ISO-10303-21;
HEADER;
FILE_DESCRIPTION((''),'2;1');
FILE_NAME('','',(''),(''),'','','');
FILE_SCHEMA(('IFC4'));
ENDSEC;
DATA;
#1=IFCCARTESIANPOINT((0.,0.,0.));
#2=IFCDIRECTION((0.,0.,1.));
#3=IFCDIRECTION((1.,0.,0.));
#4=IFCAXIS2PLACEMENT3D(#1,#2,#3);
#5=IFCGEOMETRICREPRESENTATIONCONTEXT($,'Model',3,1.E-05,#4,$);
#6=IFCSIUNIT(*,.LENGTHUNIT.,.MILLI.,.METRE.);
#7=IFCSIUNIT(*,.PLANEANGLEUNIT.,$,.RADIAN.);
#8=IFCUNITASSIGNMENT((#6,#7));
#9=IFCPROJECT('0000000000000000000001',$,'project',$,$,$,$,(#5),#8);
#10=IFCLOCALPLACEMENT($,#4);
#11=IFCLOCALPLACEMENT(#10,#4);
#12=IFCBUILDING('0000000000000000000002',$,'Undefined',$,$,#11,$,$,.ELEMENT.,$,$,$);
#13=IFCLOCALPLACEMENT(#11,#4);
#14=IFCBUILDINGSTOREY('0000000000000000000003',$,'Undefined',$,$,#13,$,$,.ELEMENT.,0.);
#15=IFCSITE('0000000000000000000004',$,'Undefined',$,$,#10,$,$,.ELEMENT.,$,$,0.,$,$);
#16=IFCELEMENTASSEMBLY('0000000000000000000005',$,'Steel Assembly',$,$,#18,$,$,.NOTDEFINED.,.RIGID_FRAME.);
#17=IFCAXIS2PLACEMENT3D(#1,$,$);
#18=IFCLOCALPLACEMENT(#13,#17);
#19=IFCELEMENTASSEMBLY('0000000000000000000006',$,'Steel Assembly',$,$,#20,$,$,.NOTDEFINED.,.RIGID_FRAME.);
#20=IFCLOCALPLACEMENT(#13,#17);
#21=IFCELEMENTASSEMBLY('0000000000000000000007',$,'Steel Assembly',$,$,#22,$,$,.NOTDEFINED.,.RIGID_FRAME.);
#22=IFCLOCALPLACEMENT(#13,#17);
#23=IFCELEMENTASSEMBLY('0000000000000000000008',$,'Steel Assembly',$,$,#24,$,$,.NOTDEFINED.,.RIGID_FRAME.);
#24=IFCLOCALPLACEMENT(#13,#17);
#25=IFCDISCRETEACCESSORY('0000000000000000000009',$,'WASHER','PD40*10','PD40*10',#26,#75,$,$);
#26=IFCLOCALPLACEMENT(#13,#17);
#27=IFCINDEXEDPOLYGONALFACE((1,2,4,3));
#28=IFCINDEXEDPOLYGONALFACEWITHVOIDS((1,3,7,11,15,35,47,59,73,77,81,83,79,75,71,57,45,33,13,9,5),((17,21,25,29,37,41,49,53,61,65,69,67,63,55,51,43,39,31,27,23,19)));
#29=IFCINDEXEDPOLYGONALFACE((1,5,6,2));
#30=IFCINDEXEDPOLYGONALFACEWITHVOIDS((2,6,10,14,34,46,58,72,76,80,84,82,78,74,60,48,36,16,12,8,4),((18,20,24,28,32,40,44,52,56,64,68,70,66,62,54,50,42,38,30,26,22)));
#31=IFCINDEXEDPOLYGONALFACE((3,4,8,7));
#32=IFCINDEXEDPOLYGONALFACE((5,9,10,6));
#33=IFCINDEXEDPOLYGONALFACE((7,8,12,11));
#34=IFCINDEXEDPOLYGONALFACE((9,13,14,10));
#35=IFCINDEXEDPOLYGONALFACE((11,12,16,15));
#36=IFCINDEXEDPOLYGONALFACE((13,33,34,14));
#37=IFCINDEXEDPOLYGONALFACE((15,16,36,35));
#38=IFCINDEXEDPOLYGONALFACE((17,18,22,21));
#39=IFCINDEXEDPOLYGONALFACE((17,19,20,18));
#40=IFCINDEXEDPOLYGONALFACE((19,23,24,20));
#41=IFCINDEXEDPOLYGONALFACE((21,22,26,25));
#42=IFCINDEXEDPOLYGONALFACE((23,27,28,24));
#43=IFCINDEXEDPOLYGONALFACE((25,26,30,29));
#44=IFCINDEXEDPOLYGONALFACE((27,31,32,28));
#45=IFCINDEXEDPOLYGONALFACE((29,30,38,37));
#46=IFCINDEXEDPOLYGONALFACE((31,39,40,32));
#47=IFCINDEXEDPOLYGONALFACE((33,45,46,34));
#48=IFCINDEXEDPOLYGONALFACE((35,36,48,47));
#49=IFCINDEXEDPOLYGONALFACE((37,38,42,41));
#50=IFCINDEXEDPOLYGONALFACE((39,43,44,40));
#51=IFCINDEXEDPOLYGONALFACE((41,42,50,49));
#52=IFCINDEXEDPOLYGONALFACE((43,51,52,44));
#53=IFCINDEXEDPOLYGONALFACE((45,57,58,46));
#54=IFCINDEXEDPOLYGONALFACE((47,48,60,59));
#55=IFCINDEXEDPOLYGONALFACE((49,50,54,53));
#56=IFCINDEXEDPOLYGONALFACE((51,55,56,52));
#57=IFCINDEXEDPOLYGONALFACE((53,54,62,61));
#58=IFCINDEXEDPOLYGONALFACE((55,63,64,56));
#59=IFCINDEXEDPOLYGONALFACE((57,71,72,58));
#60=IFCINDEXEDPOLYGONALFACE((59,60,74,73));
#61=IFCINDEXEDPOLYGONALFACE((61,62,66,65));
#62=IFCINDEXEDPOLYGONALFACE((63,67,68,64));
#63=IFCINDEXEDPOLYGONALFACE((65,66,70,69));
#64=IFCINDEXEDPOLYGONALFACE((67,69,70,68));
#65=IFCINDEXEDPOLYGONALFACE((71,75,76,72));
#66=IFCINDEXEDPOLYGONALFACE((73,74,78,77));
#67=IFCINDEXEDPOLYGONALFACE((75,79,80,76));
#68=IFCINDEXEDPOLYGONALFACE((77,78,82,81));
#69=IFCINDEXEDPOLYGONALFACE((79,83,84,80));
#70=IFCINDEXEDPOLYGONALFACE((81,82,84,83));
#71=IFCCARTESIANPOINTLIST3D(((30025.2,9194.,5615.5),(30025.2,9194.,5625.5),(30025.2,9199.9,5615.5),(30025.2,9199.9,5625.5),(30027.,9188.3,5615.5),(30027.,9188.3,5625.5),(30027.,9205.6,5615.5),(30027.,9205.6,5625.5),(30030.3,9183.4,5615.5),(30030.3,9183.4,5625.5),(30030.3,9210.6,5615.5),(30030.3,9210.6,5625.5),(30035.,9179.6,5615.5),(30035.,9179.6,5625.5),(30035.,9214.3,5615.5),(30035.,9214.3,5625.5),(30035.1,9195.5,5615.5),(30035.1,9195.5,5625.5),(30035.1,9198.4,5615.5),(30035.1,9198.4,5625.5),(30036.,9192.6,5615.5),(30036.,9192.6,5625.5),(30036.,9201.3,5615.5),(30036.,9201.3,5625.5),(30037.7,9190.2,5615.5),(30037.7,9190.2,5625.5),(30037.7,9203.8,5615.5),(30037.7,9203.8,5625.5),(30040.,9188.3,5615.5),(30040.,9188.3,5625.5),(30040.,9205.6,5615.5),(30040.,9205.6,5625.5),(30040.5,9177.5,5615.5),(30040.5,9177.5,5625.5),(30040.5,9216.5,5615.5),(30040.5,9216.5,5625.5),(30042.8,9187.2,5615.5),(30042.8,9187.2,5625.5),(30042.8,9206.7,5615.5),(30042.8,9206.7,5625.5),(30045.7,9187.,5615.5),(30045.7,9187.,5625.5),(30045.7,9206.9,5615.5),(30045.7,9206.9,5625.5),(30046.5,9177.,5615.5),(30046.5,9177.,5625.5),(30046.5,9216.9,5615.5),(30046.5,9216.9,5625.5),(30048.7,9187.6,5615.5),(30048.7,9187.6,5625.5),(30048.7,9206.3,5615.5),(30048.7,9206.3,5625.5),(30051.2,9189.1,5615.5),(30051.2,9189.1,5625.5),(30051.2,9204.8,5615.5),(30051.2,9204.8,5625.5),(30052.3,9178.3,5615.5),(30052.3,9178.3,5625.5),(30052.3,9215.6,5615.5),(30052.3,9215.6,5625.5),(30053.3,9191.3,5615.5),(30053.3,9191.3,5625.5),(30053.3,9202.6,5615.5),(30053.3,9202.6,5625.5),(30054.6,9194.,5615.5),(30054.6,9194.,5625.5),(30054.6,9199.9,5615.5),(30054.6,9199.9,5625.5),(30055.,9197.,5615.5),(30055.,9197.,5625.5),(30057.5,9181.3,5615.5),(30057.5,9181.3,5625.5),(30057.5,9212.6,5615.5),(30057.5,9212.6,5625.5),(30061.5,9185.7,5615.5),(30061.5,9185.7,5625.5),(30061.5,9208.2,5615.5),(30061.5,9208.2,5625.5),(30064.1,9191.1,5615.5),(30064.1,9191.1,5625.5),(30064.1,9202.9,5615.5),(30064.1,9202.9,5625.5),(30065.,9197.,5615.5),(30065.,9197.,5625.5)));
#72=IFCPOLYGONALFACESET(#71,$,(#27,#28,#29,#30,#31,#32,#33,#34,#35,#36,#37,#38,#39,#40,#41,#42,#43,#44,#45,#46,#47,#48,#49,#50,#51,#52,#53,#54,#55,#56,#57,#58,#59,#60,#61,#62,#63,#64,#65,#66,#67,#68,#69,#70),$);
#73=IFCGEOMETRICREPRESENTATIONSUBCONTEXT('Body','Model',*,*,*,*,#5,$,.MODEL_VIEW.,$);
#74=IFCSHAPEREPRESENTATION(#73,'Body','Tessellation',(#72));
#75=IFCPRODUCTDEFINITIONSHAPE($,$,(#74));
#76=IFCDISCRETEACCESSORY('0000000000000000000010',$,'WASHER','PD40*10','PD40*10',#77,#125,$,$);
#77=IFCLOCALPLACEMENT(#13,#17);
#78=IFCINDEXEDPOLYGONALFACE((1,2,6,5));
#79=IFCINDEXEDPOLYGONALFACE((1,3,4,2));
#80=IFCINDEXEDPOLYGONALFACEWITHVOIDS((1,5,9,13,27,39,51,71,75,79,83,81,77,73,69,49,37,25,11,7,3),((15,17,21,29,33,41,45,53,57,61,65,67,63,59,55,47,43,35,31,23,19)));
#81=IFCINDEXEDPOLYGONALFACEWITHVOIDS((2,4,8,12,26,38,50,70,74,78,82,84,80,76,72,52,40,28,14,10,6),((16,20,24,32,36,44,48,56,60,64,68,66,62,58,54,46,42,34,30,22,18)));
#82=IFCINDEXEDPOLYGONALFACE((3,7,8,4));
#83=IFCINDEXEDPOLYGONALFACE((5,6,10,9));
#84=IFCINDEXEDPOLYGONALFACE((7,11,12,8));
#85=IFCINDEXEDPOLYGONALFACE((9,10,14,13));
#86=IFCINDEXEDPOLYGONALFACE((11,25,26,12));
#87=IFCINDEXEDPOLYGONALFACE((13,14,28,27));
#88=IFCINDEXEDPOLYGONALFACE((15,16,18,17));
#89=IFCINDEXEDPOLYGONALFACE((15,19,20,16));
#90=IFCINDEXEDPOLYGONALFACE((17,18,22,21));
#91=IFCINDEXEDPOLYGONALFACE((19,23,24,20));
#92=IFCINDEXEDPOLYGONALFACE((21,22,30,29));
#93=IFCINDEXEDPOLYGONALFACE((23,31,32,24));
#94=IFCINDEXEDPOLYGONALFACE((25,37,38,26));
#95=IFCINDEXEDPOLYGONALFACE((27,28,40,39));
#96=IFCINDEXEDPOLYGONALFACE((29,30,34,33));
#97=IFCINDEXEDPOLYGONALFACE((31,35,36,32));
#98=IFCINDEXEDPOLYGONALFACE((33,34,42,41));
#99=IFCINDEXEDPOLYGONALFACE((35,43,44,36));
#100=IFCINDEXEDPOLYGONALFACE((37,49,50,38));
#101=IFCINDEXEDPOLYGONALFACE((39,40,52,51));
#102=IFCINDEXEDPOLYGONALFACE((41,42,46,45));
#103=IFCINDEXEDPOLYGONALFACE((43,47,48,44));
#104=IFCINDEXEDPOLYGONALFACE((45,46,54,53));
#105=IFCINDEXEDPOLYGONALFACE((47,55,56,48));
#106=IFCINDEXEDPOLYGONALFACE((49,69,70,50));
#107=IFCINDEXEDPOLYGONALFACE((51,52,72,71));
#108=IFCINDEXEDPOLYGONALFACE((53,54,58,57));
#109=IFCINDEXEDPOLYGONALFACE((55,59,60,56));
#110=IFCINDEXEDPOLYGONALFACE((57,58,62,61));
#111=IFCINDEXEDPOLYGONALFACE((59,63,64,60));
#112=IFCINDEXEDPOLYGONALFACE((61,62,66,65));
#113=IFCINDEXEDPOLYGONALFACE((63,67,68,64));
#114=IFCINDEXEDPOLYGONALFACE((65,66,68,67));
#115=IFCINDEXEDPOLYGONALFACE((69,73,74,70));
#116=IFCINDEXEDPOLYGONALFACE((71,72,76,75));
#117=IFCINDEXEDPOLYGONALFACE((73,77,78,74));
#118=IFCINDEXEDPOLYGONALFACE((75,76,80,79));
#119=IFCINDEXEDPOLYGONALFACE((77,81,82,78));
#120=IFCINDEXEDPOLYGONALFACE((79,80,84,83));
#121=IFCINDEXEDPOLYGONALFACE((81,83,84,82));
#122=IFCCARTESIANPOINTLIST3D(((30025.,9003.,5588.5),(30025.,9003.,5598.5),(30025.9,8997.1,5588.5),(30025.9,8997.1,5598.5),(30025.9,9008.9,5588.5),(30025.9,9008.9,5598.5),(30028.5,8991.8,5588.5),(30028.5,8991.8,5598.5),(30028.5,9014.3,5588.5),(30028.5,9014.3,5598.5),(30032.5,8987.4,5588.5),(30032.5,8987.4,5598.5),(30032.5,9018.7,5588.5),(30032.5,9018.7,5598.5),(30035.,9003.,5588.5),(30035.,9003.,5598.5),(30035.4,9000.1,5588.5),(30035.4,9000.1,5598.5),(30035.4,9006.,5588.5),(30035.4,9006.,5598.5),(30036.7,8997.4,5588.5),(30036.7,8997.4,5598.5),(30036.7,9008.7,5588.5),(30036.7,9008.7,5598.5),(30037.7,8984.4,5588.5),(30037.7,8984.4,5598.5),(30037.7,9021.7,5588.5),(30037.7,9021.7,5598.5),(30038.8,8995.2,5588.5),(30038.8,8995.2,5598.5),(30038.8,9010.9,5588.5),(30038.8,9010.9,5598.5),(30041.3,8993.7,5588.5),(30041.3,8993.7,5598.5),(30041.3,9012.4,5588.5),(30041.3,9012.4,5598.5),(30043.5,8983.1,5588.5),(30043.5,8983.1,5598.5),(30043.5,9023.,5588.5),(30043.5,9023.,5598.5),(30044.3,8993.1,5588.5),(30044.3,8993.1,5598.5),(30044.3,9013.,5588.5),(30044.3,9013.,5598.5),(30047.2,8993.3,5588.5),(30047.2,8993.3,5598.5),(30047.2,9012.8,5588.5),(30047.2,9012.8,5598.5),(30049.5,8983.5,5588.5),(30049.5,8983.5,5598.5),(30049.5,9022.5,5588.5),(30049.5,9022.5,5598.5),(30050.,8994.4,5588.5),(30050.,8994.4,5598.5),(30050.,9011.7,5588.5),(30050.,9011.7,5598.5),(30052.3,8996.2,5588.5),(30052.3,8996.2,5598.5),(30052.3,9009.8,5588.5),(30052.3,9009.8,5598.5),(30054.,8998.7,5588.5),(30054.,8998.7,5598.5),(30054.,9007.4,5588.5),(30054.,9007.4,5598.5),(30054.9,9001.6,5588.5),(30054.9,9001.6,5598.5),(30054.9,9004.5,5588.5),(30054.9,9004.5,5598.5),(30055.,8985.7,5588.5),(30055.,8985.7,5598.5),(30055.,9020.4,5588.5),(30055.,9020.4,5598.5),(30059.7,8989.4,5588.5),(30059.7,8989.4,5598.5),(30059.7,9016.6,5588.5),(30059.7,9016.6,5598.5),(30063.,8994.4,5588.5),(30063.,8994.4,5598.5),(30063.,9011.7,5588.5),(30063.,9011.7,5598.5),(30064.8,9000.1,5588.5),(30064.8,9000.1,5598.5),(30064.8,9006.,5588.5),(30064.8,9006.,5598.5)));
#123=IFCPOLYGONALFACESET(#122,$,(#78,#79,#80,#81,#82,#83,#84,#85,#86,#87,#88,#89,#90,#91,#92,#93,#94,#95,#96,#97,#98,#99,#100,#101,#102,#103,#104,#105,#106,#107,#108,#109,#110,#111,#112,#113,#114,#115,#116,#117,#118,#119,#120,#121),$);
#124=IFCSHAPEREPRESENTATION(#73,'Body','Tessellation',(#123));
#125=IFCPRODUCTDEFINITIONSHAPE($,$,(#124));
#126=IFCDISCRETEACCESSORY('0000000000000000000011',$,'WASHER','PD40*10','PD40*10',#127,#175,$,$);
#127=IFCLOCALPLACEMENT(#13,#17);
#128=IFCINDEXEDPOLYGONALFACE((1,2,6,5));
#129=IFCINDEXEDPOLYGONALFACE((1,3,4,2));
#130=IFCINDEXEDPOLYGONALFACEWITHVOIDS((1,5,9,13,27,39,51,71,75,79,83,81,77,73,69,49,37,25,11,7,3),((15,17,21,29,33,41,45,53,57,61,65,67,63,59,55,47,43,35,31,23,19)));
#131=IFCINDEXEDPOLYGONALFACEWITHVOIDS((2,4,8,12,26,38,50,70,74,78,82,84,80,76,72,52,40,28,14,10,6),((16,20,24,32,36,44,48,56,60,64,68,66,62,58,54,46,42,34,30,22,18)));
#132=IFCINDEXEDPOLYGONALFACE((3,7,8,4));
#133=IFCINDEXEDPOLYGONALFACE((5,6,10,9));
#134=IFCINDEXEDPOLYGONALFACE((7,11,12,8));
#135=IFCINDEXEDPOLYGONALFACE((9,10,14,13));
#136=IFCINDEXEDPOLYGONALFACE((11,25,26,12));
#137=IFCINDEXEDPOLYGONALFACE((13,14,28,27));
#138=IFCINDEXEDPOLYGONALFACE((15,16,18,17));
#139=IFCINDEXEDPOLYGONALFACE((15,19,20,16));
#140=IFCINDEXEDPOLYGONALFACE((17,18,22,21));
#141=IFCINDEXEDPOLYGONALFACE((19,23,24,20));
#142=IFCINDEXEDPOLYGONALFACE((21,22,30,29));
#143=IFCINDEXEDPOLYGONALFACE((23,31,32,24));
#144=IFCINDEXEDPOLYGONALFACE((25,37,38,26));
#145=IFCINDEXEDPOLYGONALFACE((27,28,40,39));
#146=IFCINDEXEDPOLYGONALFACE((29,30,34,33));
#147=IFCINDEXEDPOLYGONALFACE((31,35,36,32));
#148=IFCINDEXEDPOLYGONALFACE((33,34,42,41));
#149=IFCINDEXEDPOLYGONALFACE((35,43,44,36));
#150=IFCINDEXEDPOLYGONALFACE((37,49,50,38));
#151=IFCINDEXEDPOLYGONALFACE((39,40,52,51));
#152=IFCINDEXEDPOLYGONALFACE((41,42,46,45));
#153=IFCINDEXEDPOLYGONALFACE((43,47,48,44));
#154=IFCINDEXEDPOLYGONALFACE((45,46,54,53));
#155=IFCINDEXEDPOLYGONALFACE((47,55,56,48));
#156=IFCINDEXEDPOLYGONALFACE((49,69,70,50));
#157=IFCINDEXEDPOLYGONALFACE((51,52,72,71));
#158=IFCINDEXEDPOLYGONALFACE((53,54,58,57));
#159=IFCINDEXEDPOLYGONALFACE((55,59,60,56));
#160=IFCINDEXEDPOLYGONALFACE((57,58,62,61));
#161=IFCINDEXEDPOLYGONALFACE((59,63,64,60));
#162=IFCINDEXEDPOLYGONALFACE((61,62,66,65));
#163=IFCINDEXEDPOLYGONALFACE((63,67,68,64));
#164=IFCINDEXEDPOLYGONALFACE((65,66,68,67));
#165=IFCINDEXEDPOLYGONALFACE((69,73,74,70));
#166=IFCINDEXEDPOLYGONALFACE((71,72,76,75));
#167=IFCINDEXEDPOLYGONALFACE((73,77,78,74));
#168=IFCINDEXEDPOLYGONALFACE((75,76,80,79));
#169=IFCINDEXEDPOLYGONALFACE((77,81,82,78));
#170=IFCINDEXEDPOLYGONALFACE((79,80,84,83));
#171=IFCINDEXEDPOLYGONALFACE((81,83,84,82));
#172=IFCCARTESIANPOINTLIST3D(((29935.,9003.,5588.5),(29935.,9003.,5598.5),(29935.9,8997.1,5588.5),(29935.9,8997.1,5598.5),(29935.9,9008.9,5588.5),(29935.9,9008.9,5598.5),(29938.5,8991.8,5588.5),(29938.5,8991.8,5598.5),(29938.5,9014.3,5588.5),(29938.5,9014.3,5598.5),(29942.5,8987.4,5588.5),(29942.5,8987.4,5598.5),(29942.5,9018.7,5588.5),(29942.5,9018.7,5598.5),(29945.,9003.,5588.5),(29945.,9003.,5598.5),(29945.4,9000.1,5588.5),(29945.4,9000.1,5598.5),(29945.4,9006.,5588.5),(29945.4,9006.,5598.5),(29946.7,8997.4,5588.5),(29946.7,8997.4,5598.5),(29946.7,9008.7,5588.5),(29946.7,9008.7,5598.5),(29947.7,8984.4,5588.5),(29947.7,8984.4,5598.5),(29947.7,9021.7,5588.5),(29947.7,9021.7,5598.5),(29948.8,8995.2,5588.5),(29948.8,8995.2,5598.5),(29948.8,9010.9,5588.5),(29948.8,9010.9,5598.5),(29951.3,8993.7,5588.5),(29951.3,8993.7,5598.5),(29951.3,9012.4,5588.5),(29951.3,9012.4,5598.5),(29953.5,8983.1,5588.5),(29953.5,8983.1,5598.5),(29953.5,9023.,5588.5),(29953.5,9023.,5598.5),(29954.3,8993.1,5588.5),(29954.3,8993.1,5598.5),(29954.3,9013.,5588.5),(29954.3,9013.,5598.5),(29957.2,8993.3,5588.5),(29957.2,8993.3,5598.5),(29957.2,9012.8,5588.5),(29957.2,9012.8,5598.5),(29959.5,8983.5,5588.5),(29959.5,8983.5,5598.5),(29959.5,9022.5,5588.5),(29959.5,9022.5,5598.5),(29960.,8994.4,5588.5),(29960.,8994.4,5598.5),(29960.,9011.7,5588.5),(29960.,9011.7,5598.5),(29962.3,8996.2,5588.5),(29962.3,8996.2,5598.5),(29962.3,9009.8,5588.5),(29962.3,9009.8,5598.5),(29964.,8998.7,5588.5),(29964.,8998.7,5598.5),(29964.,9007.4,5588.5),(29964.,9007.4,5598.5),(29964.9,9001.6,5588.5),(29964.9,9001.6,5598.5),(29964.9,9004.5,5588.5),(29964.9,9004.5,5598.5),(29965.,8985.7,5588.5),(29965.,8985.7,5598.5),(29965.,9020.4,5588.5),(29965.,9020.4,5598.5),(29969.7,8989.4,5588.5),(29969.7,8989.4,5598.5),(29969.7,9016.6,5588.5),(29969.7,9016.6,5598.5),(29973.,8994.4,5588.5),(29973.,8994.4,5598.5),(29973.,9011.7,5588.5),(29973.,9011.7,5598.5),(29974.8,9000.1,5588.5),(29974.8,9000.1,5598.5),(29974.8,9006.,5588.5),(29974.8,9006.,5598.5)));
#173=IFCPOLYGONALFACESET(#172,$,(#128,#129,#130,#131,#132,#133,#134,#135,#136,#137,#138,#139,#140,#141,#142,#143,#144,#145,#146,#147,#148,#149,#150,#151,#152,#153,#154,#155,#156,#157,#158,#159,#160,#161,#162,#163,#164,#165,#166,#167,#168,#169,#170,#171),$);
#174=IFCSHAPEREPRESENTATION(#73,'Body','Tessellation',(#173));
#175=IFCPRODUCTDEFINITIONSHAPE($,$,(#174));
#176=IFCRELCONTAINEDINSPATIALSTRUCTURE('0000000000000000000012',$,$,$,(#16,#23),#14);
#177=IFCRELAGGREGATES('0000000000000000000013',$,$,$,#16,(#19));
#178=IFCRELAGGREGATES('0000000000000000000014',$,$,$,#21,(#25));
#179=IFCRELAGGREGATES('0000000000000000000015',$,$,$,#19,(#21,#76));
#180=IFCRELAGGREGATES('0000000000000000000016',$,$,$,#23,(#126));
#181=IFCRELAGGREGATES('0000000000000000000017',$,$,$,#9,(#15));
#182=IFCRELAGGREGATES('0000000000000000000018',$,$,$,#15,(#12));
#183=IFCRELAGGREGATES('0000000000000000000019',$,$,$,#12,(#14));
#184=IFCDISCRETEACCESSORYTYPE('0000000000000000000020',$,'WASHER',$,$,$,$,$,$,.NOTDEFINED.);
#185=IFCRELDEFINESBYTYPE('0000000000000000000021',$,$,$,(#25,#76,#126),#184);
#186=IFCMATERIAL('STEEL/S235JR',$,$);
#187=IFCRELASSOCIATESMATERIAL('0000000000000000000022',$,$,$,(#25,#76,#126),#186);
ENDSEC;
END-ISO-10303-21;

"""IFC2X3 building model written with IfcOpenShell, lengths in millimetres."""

from ifc_helpers import new_model, si_unit, frame, origin_with_axes, origin_2d_with_axis, place, context, subcontext, project, spatial, hollow_circle, extrude, material, type_object, element, aggregate, save


model = new_model("IFC2X3")

# Units and contexts
model_context = context("Model", 3, precision=1e-05, world=origin_with_axes())
body_context = subcontext(model_context, "Body", "Model", "MODEL_VIEW")
ifc_project = project(units=[si_unit("LENGTHUNIT", "METRE", prefix="MILLI"), si_unit("PLANEANGLEUNIT", "RADIAN")], contexts=[model_context])

# Site, building, storey
site_placement = place(None, origin_with_axes())
site = spatial("IfcSite", under=ifc_project, at=site_placement, Name="Undefined", CompositionType="ELEMENT", RefElevation=0.0)
building_placement = place(site_placement, origin_with_axes())
building = spatial("IfcBuilding", under=site, at=building_placement, Name="Undefined", CompositionType="ELEMENT")
storey_placement = place(building_placement, origin_with_axes())
storey = spatial("IfcBuildingStorey", under=building, at=storey_placement, Name="Undefined", CompositionType="ELEMENT", Elevation=0.0)

# Shared definitions
ifc_material_1 = material(Name="STEEL/S235JR")

# Element assemblies
assembly_1_placement = place(storey_placement, origin_with_axes())
assembly_1 = element("IfcElementAssembly", 1, at=assembly_1_placement, inside=storey, Name="Steel Assembly", AssemblyPlace="NOTDEFINED", PredefinedType="RIGID_FRAME")
assembly_2_placement = place(assembly_1_placement, origin_with_axes())
assembly_2 = element("IfcElementAssembly", 2, at=assembly_2_placement, Name="Steel Assembly", AssemblyPlace="NOTDEFINED", PredefinedType="RIGID_FRAME")
aggregate(assembly_1, [assembly_2])
assembly_3_placement = place(assembly_2_placement, origin_with_axes())
assembly_3 = element("IfcElementAssembly", 3, at=assembly_3_placement, Name="Steel Assembly", AssemblyPlace="NOTDEFINED", PredefinedType="RIGID_FRAME")

# Element assembly
assembly_4_placement = place(storey_placement, origin_with_axes())
assembly_4 = element("IfcElementAssembly", 4, at=assembly_4_placement, inside=storey, Name="Steel Assembly", AssemblyPlace="NOTDEFINED", PredefinedType="RIGID_FRAME")

# Discrete accessories
discrete_accessory_type_1 = type_object("IfcDiscreteAccessoryType", Name="WASHER")
discrete_accessory_1_placement = place(assembly_3_placement, frame((30045.0, 9197.0, 5625.5), z_axis=(0.0, 1.0, 0.0), x_axis=(0.0, 0.0, -1.0)))
discrete_accessory_1 = element("IfcDiscreteAccessory", 5, at=discrete_accessory_1_placement, type_object=discrete_accessory_type_1, material=ifc_material_1, Name="WASHER", Description="PD40*10", ObjectType="PD40*10", context=body_context, shape_type="SweptSolid", body=[
    extrude(hollow_circle(Radius=20.0, WallThickness=10.0, at=origin_2d_with_axis()), frame((10.0, 0.0, 0.0), z_axis=(-1.0, 0.0, 0.0), x_axis=(0.0, -1.0, 0.0)), (0.0, 0.0, 1.0), 10.0),
])
aggregate(assembly_3, [discrete_accessory_1])
discrete_accessory_2_placement = place(assembly_2_placement, frame((30045.0, 9003.0, 5598.5), z_axis=(0.0, -1.0, 0.0), x_axis=(0.0, 0.0, -1.0)))
discrete_accessory_2 = element("IfcDiscreteAccessory", 6, at=discrete_accessory_2_placement, type_object=discrete_accessory_type_1, material=ifc_material_1, Name="WASHER", Description="PD40*10", ObjectType="PD40*10", context=body_context, shape_type="SweptSolid", body=[
    extrude(hollow_circle(Radius=20.0, WallThickness=10.0, at=origin_2d_with_axis()), frame((10.0, 0.0, 0.0), z_axis=(-1.0, 0.0, 0.0), x_axis=(0.0, -1.0, 0.0)), (0.0, 0.0, 1.0), 10.0),
])
aggregate(assembly_2, [assembly_3, discrete_accessory_2])
discrete_accessory_3_placement = place(assembly_4_placement, frame((29955.0, 9003.0, 5598.5), z_axis=(0.0, -1.0, 0.0), x_axis=(0.0, 0.0, -1.0)))
discrete_accessory_3 = element("IfcDiscreteAccessory", 7, at=discrete_accessory_3_placement, type_object=discrete_accessory_type_1, material=ifc_material_1, Name="WASHER", Description="PD40*10", ObjectType="PD40*10", context=body_context, shape_type="SweptSolid", body=[
    extrude(hollow_circle(Radius=20.0, WallThickness=10.0, at=origin_2d_with_axis()), frame((10.0, 0.0, 0.0), z_axis=(-1.0, 0.0, 0.0), x_axis=(0.0, -1.0, 0.0)), (0.0, 0.0, 1.0), 10.0),
])
aggregate(assembly_4, [discrete_accessory_3])

save(model, "model.ifc")
